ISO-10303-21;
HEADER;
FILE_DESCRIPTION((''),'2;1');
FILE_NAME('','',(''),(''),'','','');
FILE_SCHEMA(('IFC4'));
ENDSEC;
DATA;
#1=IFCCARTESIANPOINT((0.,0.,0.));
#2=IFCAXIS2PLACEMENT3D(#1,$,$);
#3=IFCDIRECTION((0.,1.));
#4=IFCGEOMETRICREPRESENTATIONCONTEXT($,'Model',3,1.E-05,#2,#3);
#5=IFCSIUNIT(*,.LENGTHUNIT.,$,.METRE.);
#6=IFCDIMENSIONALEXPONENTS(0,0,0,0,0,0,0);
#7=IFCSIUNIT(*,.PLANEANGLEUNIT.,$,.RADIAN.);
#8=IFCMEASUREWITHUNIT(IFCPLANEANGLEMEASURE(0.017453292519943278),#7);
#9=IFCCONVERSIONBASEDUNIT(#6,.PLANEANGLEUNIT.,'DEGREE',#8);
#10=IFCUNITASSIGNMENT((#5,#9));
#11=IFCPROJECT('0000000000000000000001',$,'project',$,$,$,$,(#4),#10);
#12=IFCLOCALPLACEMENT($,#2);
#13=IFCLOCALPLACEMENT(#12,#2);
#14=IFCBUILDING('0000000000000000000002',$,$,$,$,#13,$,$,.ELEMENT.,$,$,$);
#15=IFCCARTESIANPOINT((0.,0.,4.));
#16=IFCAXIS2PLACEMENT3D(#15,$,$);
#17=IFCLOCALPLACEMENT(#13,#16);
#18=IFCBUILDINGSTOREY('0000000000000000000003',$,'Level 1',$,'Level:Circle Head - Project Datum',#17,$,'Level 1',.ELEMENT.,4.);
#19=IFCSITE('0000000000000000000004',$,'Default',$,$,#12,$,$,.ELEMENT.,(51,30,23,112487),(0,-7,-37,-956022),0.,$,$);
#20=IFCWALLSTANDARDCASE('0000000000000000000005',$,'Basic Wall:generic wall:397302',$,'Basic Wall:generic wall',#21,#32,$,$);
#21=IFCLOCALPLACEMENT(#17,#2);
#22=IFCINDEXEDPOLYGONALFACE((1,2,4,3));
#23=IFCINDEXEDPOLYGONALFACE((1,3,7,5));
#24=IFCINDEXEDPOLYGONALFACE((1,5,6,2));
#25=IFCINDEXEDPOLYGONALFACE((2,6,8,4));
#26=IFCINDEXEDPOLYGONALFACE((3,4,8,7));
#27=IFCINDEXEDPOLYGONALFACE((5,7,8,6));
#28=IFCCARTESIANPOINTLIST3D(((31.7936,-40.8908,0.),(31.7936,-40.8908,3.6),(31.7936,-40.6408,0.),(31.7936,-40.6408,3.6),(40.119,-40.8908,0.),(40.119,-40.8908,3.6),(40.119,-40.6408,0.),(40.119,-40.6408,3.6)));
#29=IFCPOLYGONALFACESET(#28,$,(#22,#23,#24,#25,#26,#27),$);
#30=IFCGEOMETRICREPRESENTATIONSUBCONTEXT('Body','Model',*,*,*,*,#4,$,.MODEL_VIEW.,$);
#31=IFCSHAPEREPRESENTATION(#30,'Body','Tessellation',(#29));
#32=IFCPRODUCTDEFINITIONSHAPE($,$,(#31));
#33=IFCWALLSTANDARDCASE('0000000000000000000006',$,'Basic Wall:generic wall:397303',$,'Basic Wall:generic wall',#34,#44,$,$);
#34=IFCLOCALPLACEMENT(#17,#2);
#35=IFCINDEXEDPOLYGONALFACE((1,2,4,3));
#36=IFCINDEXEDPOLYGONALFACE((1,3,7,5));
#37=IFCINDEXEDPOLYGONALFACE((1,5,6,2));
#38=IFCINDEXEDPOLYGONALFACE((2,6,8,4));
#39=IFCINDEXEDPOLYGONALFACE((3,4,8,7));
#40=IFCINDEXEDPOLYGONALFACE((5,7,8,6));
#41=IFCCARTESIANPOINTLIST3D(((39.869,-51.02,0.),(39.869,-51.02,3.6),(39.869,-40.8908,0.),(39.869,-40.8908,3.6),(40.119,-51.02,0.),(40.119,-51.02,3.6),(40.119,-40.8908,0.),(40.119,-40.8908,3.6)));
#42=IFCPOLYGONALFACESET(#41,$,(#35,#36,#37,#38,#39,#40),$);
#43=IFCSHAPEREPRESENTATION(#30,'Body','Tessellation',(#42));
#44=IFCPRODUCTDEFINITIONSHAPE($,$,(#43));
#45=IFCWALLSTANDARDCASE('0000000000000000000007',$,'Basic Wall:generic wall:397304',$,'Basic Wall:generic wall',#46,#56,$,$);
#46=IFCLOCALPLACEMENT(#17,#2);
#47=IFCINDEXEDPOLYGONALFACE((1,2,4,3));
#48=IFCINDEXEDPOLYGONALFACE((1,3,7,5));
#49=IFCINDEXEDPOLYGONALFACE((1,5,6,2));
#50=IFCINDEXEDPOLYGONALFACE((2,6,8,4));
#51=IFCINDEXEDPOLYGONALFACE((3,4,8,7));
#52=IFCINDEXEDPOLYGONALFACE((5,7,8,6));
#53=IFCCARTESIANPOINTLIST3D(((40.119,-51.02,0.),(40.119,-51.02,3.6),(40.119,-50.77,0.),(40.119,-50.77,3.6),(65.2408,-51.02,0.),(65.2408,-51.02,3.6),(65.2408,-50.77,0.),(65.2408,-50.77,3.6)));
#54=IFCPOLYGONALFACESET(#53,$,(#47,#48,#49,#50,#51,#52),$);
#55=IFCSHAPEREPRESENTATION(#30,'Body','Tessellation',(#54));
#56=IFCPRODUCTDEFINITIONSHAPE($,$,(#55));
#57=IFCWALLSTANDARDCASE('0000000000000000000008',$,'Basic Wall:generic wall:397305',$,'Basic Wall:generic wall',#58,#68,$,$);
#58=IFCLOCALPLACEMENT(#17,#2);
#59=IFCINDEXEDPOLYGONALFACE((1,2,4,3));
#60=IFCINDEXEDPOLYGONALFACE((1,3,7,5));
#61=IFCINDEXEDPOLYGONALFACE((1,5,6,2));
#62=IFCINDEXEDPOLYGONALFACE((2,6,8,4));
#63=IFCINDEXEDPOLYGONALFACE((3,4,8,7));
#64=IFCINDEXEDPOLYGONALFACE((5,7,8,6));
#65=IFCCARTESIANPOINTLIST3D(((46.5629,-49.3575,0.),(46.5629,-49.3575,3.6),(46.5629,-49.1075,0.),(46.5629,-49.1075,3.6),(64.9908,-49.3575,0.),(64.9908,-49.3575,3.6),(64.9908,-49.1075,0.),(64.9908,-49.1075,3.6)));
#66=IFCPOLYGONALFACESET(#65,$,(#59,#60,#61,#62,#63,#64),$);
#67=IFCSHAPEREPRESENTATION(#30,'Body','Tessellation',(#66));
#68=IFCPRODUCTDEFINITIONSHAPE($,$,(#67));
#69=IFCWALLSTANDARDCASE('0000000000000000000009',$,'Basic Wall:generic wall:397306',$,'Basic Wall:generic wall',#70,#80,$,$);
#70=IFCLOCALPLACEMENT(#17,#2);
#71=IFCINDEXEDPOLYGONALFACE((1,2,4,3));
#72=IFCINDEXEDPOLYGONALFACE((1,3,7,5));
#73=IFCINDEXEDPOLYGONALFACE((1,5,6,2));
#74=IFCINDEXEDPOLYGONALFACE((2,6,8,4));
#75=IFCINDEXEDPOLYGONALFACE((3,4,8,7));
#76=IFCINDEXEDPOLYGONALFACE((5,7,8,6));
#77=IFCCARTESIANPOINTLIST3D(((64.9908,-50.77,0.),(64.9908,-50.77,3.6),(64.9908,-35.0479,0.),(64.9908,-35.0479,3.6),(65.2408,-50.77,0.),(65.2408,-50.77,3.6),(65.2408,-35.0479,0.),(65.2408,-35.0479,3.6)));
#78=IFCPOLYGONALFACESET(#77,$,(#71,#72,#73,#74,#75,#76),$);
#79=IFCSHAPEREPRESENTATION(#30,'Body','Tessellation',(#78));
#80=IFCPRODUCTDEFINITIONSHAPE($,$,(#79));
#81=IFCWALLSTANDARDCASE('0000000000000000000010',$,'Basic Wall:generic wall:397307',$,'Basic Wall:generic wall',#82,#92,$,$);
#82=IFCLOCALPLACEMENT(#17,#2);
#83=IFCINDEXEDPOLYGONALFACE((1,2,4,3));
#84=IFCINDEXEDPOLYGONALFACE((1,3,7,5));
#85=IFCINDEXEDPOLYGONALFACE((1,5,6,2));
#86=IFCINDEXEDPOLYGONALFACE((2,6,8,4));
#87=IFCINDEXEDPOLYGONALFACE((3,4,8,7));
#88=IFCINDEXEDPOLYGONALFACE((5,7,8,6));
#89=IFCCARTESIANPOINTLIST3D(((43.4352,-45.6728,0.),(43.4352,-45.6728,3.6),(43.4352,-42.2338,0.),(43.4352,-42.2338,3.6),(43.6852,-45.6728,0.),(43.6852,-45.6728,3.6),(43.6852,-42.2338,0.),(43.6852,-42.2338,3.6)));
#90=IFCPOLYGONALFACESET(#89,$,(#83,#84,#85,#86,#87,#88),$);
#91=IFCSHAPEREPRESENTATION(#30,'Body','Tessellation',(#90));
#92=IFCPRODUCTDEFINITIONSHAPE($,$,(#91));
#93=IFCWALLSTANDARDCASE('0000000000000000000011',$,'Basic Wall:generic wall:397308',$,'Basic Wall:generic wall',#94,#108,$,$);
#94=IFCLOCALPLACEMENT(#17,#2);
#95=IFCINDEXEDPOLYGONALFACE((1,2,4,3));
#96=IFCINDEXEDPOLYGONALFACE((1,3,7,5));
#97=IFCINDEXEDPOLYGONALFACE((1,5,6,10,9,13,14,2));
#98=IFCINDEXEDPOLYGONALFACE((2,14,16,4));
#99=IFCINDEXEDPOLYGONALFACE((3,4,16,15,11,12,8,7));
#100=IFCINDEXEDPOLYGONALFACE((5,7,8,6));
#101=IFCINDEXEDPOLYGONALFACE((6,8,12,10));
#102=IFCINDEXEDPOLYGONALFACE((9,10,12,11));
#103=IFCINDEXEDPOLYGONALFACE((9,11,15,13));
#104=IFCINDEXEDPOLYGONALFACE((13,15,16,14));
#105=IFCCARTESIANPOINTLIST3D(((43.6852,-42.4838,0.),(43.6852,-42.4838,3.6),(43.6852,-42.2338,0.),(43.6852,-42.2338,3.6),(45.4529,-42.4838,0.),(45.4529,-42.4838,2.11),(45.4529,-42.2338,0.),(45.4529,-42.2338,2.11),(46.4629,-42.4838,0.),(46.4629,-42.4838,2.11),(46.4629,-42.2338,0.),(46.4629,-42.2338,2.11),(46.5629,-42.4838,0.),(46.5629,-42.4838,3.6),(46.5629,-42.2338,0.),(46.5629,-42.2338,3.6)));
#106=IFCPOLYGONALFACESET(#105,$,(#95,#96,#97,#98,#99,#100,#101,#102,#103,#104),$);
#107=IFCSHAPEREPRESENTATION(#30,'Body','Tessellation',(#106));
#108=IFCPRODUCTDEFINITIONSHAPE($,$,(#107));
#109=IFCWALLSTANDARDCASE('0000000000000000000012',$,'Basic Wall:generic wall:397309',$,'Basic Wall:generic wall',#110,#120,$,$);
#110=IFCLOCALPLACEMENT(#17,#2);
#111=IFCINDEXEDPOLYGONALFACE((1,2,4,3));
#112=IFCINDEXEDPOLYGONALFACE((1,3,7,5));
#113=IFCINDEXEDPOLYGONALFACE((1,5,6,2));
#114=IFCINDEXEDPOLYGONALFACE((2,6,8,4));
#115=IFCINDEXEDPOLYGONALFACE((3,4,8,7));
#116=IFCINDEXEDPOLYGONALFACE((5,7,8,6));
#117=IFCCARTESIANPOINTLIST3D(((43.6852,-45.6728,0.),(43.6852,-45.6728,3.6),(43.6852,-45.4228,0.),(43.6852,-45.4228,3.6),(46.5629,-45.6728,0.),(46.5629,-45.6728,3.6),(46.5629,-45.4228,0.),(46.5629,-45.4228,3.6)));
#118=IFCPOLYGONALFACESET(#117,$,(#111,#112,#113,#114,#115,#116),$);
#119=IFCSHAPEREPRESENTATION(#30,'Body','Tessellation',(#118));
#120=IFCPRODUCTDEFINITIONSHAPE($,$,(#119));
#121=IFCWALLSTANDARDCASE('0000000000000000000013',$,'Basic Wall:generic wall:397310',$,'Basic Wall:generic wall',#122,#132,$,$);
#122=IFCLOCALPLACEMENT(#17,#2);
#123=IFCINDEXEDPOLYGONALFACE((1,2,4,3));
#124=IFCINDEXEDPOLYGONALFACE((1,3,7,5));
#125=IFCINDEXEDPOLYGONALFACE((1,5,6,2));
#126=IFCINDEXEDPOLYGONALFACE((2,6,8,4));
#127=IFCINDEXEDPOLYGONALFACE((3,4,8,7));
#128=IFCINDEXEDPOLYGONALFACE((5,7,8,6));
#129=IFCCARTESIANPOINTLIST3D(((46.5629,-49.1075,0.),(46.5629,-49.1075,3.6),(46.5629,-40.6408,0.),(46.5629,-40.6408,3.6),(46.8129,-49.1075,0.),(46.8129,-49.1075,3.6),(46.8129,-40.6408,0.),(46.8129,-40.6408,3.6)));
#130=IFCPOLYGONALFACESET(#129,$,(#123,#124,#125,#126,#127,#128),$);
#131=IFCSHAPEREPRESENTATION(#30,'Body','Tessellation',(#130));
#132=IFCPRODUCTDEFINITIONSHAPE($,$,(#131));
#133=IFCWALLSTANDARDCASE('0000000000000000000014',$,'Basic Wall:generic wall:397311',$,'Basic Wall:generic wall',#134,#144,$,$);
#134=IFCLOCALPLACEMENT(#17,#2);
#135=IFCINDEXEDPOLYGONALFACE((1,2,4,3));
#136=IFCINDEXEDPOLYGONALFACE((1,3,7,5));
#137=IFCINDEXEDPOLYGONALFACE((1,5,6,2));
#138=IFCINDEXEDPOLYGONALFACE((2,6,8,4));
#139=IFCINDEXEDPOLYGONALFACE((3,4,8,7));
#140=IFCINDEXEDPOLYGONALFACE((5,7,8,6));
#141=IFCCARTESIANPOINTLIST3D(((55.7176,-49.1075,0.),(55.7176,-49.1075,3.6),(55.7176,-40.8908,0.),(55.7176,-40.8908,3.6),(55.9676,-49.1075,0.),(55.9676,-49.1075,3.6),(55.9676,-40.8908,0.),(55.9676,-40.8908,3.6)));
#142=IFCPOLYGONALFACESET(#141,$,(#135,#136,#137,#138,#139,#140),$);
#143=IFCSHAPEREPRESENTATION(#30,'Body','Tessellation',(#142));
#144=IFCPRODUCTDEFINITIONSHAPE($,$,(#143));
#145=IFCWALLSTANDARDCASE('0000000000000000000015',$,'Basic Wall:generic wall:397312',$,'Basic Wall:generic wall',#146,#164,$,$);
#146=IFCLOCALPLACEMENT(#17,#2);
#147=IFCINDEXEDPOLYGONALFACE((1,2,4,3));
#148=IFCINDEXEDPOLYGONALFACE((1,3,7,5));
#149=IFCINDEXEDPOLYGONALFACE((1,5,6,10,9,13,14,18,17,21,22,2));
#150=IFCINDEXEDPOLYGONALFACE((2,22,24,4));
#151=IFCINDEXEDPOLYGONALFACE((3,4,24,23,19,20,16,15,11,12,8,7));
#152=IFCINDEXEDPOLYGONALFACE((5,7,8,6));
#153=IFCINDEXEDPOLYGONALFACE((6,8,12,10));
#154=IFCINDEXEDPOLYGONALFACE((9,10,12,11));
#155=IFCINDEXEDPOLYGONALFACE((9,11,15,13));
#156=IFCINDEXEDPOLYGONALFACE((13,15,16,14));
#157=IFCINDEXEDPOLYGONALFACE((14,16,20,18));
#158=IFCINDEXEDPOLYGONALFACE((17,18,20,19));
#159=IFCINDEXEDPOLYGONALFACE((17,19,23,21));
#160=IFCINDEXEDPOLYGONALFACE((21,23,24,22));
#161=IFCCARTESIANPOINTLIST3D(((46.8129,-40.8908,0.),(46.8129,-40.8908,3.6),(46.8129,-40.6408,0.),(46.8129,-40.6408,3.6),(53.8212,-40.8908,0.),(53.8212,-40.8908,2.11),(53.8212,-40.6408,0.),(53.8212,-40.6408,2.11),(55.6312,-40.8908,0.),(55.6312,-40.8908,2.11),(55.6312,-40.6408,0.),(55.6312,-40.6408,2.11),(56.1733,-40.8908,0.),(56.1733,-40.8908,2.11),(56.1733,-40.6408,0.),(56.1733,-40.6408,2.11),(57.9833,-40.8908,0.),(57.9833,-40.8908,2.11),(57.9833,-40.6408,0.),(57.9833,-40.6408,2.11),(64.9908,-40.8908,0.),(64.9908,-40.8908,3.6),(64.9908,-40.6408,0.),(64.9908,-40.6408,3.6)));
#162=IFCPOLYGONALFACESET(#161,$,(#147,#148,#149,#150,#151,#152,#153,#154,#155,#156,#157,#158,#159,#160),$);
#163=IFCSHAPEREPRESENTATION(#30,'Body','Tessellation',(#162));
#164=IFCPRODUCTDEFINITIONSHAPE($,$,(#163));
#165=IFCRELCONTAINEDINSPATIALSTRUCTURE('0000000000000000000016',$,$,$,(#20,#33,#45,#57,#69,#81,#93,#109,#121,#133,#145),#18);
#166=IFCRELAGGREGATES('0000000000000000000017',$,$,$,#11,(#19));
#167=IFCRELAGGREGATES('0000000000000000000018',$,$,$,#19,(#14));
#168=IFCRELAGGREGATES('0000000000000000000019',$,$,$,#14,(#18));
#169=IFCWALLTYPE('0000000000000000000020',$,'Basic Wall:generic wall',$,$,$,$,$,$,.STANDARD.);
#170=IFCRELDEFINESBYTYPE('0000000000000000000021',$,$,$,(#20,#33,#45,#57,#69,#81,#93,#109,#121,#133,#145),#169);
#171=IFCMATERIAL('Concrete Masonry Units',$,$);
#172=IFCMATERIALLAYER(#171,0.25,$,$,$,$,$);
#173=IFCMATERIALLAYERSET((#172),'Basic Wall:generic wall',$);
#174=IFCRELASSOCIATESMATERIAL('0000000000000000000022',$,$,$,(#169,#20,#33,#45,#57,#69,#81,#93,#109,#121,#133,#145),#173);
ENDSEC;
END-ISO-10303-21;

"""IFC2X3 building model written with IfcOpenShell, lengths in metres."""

from ifc_helpers import new_model, entity, si_unit, converted_unit, direction, frame, frame_2d, origin, place, context, subcontext, project, spatial, rectangle, extrude, material, layer, layer_set, layer_usage, type_object, element, save


model = new_model("IFC2X3")

# Units and contexts
model_context = context("Model", 3, precision=1e-05, world=origin(), true_north=direction((0.0, 1.0)))
body_context = subcontext(model_context, "Body", "Model", "MODEL_VIEW")
ifc_project = project(units=[si_unit("LENGTHUNIT", "METRE"), converted_unit("PLANEANGLEUNIT", "DEGREE", entity("IfcPlaneAngleMeasure", 0.017453292519943278), si_unit("PLANEANGLEUNIT", "RADIAN"), dimensions=[0, 0, 0, 0, 0, 0, 0])], contexts=[model_context])

# Site, building, storey
site_placement = place(None, origin())
site = spatial("IfcSite", under=ifc_project, at=site_placement, Name="Default", CompositionType="ELEMENT", RefLatitude=(51, 30, 23, 112487), RefLongitude=(0, -7, -37, -956022), RefElevation=0.0)
building_placement = place(site_placement, origin())
building = spatial("IfcBuilding", under=site, at=building_placement, CompositionType="ELEMENT")
storey_placement = place(building_placement, frame((0.0, 0.0, 4.0)))
storey = spatial("IfcBuildingStorey", under=building, at=storey_placement, Name="Level 1", ObjectType="Level:Circle Head - Project Datum", LongName="Level 1", CompositionType="ELEMENT", Elevation=4.0)

# Walls
ifc_material = material(Name="Concrete Masonry Units")
ifc_layer = layer(ifc_material, 0.25)
ifc_layer_set = layer_set([ifc_layer], Name="Basic Wall:generic wall")
ifc_layer_usage_1 = layer_usage(ifc_layer_set, "AXIS2", "NEGATIVE", 0.125)
wall_type = type_object("IfcWallType", Name="Basic Wall:generic wall", PredefinedType="STANDARD", material=ifc_layer_set)
wall_1_placement = place(storey_placement, frame((31.7936, -40.7658, 0.0)))
element("IfcWallStandardCase", 1, at=wall_1_placement, inside=storey, type_object=wall_type, material=ifc_layer_usage_1, Name="Basic Wall:generic wall:397302", ObjectType="Basic Wall:generic wall", context=body_context, shape_type="SweptSolid", body=[
    extrude(rectangle(XDim=8.3254, YDim=0.25, at=frame_2d((4.1627, 0.0), x_axis=(-1.0, 0.0))), origin(), (0.0, 0.0, 1.0), 3.6),
])
ifc_layer_usage_2 = layer_usage(ifc_layer_set, "AXIS2", "NEGATIVE", 0.125)
wall_2_placement = place(storey_placement, frame((39.994, -40.8908, 0.0), z_axis=(0.0, 0.0, 1.0), x_axis=(0.0, -1.0, 0.0)))
element("IfcWallStandardCase", 2, at=wall_2_placement, inside=storey, type_object=wall_type, material=ifc_layer_usage_2, Name="Basic Wall:generic wall:397303", ObjectType="Basic Wall:generic wall", context=body_context, shape_type="SweptSolid", body=[
    extrude(rectangle(XDim=10.1292, YDim=0.25, at=frame_2d((5.0646, 0.0), x_axis=(-1.0, 0.0))), origin(), (0.0, 0.0, 1.0), 3.6),
])
ifc_layer_usage_3 = layer_usage(ifc_layer_set, "AXIS2", "NEGATIVE", 0.125)
wall_3_placement = place(storey_placement, frame((40.119, -50.895, 0.0)))
element("IfcWallStandardCase", 3, at=wall_3_placement, inside=storey, type_object=wall_type, material=ifc_layer_usage_3, Name="Basic Wall:generic wall:397304", ObjectType="Basic Wall:generic wall", context=body_context, shape_type="SweptSolid", body=[
    extrude(rectangle(XDim=25.1218, YDim=0.25, at=frame_2d((12.5609, 0.0), x_axis=(-1.0, 0.0))), origin(), (0.0, 0.0, 1.0), 3.6),
])
ifc_layer_usage_4 = layer_usage(ifc_layer_set, "AXIS2", "NEGATIVE", 0.125)
wall_4_placement = place(storey_placement, frame((64.9908, -49.2325, 0.0), z_axis=(0.0, 0.0, 1.0), x_axis=(-1.0, 0.0, 0.0)))
element("IfcWallStandardCase", 4, at=wall_4_placement, inside=storey, type_object=wall_type, material=ifc_layer_usage_4, Name="Basic Wall:generic wall:397305", ObjectType="Basic Wall:generic wall", context=body_context, shape_type="SweptSolid", body=[
    extrude(rectangle(XDim=18.4279, YDim=0.25, at=frame_2d((9.2139, 0.0), x_axis=(-1.0, 0.0))), origin(), (0.0, 0.0, 1.0), 3.6),
])
ifc_layer_usage_5 = layer_usage(ifc_layer_set, "AXIS2", "NEGATIVE", 0.125)
wall_5_placement = place(storey_placement, frame((65.1158, -50.77, 0.0), z_axis=(0.0, 0.0, 1.0), x_axis=(0.0, 1.0, 0.0)))
element("IfcWallStandardCase", 5, at=wall_5_placement, inside=storey, type_object=wall_type, material=ifc_layer_usage_5, Name="Basic Wall:generic wall:397306", ObjectType="Basic Wall:generic wall", context=body_context, shape_type="SweptSolid", body=[
    extrude(rectangle(XDim=15.7221, YDim=0.25, at=frame_2d((7.861, 0.0), x_axis=(-1.0, 0.0))), origin(), (0.0, 0.0, 1.0), 3.6),
])
ifc_layer_usage_6 = layer_usage(ifc_layer_set, "AXIS2", "NEGATIVE", 0.125)
wall_6_placement = place(storey_placement, frame((43.5602, -45.6728, 0.0), z_axis=(0.0, 0.0, 1.0), x_axis=(0.0, 1.0, 0.0)))
element("IfcWallStandardCase", 6, at=wall_6_placement, inside=storey, type_object=wall_type, material=ifc_layer_usage_6, Name="Basic Wall:generic wall:397307", ObjectType="Basic Wall:generic wall", context=body_context, shape_type="SweptSolid", body=[
    extrude(rectangle(XDim=3.4391, YDim=0.25, at=frame_2d((1.7195, 0.0), x_axis=(-1.0, 0.0))), origin(), (0.0, 0.0, 1.0), 3.6),
])

# Wall, opening
ifc_layer_usage_7 = layer_usage(ifc_layer_set, "AXIS2", "NEGATIVE", 0.125)
wall_7_placement = place(storey_placement, frame((43.6852, -42.3588, 0.0)))
wall_7 = element("IfcWallStandardCase", 7, at=wall_7_placement, inside=storey, type_object=wall_type, material=ifc_layer_usage_7, Name="Basic Wall:generic wall:397308", ObjectType="Basic Wall:generic wall", context=body_context, shape_type="SweptSolid", body=[
    extrude(rectangle(XDim=2.8776, YDim=0.25, at=frame_2d((1.4388, 0.0), x_axis=(1.0, 0.0))), origin(), (0.0, 0.0, 1.0), 3.6),
])
opening_1_placement = place(wall_7_placement, frame((2.7776, 0.125, 0.0)))
element("IfcOpeningElement", 8, at=opening_1_placement, cuts=wall_7, ObjectType="Opening", context=body_context, shape_type="SweptSolid", body=[
    extrude(rectangle(XDim=2.11, YDim=1.01, at=frame_2d((1.055, 0.505), x_axis=(1.0, 0.0))), frame((0.0, 0.0, 0.0), z_axis=(0.0, -1.0, 0.0), x_axis=(0.0, 0.0, 1.0)), (0.0, 0.0, 1.0), 0.25),
])

# Walls
ifc_layer_usage_8 = layer_usage(ifc_layer_set, "AXIS2", "NEGATIVE", 0.125)
wall_8_placement = place(storey_placement, frame((46.5629, -45.5478, 0.0), z_axis=(0.0, 0.0, 1.0), x_axis=(-1.0, 0.0, 0.0)))
element("IfcWallStandardCase", 9, at=wall_8_placement, inside=storey, type_object=wall_type, material=ifc_layer_usage_8, Name="Basic Wall:generic wall:397309", ObjectType="Basic Wall:generic wall", context=body_context, shape_type="SweptSolid", body=[
    extrude(rectangle(XDim=2.8776, YDim=0.25, at=frame_2d((1.4388, 0.0), x_axis=(-1.0, 0.0))), origin(), (0.0, 0.0, 1.0), 3.6),
])
ifc_layer_usage_9 = layer_usage(ifc_layer_set, "AXIS2", "NEGATIVE", 0.125)
wall_9_placement = place(storey_placement, frame((46.6879, -40.6408, 0.0), z_axis=(0.0, 0.0, 1.0), x_axis=(0.0, -1.0, 0.0)))
element("IfcWallStandardCase", 10, at=wall_9_placement, inside=storey, type_object=wall_type, material=ifc_layer_usage_9, Name="Basic Wall:generic wall:397310", ObjectType="Basic Wall:generic wall", context=body_context, shape_type="SweptSolid", body=[
    extrude(rectangle(XDim=8.4668, YDim=0.25, at=frame_2d((4.2334, 0.0), x_axis=(-1.0, 0.0))), origin(), (0.0, 0.0, 1.0), 3.6),
])
ifc_layer_usage_10 = layer_usage(ifc_layer_set, "AXIS2", "NEGATIVE", 0.125)
wall_10_placement = place(storey_placement, frame((55.8426, -49.1075, 0.0), z_axis=(0.0, 0.0, 1.0), x_axis=(0.0, 1.0, 0.0)))
element("IfcWallStandardCase", 11, at=wall_10_placement, inside=storey, type_object=wall_type, material=ifc_layer_usage_10, Name="Basic Wall:generic wall:397311", ObjectType="Basic Wall:generic wall", context=body_context, shape_type="SweptSolid", body=[
    extrude(rectangle(XDim=8.2168, YDim=0.25, at=frame_2d((4.1084, 0.0), x_axis=(-1.0, 0.0))), origin(), (0.0, 0.0, 1.0), 3.6),
])

# Wall, openings
ifc_layer_usage_11 = layer_usage(ifc_layer_set, "AXIS2", "NEGATIVE", 0.125)
wall_11_placement = place(storey_placement, frame((64.9908, -40.7658, 0.0), z_axis=(0.0, 0.0, 1.0), x_axis=(-1.0, 0.0, 0.0)))
wall_11 = element("IfcWallStandardCase", 12, at=wall_11_placement, inside=storey, type_object=wall_type, material=ifc_layer_usage_11, Name="Basic Wall:generic wall:397312", ObjectType="Basic Wall:generic wall", context=body_context, shape_type="SweptSolid", body=[
    extrude(rectangle(XDim=18.1779, YDim=0.25, at=frame_2d((9.0889, 0.0), x_axis=(1.0, 0.0))), origin(), (0.0, 0.0, 1.0), 3.6),
])
opening_2_placement = place(wall_11_placement, frame((7.0075, -0.125, 0.0)))
element("IfcOpeningElement", 13, at=opening_2_placement, cuts=wall_11, ObjectType="Opening", context=body_context, shape_type="SweptSolid", body=[
    extrude(rectangle(XDim=2.11, YDim=1.81, at=frame_2d((1.055, 0.905), x_axis=(-1.0, 0.0))), frame((0.0, 0.0, 0.0), z_axis=(0.0, 1.0, 0.0), x_axis=(0.0, 0.0, 1.0)), (0.0, 0.0, 1.0), 0.25),
])
opening_3_placement = place(wall_11_placement, frame((9.3596, -0.125, 0.0)))
element("IfcOpeningElement", 14, at=opening_3_placement, cuts=wall_11, ObjectType="Opening", context=body_context, shape_type="SweptSolid", body=[
    extrude(rectangle(XDim=2.11, YDim=1.81, at=frame_2d((1.055, 0.905), x_axis=(-1.0, 0.0))), frame((0.0, 0.0, 0.0), z_axis=(0.0, 1.0, 0.0), x_axis=(0.0, 0.0, 1.0)), (0.0, 0.0, 1.0), 0.25),
])

save(model, "model.ifc")
